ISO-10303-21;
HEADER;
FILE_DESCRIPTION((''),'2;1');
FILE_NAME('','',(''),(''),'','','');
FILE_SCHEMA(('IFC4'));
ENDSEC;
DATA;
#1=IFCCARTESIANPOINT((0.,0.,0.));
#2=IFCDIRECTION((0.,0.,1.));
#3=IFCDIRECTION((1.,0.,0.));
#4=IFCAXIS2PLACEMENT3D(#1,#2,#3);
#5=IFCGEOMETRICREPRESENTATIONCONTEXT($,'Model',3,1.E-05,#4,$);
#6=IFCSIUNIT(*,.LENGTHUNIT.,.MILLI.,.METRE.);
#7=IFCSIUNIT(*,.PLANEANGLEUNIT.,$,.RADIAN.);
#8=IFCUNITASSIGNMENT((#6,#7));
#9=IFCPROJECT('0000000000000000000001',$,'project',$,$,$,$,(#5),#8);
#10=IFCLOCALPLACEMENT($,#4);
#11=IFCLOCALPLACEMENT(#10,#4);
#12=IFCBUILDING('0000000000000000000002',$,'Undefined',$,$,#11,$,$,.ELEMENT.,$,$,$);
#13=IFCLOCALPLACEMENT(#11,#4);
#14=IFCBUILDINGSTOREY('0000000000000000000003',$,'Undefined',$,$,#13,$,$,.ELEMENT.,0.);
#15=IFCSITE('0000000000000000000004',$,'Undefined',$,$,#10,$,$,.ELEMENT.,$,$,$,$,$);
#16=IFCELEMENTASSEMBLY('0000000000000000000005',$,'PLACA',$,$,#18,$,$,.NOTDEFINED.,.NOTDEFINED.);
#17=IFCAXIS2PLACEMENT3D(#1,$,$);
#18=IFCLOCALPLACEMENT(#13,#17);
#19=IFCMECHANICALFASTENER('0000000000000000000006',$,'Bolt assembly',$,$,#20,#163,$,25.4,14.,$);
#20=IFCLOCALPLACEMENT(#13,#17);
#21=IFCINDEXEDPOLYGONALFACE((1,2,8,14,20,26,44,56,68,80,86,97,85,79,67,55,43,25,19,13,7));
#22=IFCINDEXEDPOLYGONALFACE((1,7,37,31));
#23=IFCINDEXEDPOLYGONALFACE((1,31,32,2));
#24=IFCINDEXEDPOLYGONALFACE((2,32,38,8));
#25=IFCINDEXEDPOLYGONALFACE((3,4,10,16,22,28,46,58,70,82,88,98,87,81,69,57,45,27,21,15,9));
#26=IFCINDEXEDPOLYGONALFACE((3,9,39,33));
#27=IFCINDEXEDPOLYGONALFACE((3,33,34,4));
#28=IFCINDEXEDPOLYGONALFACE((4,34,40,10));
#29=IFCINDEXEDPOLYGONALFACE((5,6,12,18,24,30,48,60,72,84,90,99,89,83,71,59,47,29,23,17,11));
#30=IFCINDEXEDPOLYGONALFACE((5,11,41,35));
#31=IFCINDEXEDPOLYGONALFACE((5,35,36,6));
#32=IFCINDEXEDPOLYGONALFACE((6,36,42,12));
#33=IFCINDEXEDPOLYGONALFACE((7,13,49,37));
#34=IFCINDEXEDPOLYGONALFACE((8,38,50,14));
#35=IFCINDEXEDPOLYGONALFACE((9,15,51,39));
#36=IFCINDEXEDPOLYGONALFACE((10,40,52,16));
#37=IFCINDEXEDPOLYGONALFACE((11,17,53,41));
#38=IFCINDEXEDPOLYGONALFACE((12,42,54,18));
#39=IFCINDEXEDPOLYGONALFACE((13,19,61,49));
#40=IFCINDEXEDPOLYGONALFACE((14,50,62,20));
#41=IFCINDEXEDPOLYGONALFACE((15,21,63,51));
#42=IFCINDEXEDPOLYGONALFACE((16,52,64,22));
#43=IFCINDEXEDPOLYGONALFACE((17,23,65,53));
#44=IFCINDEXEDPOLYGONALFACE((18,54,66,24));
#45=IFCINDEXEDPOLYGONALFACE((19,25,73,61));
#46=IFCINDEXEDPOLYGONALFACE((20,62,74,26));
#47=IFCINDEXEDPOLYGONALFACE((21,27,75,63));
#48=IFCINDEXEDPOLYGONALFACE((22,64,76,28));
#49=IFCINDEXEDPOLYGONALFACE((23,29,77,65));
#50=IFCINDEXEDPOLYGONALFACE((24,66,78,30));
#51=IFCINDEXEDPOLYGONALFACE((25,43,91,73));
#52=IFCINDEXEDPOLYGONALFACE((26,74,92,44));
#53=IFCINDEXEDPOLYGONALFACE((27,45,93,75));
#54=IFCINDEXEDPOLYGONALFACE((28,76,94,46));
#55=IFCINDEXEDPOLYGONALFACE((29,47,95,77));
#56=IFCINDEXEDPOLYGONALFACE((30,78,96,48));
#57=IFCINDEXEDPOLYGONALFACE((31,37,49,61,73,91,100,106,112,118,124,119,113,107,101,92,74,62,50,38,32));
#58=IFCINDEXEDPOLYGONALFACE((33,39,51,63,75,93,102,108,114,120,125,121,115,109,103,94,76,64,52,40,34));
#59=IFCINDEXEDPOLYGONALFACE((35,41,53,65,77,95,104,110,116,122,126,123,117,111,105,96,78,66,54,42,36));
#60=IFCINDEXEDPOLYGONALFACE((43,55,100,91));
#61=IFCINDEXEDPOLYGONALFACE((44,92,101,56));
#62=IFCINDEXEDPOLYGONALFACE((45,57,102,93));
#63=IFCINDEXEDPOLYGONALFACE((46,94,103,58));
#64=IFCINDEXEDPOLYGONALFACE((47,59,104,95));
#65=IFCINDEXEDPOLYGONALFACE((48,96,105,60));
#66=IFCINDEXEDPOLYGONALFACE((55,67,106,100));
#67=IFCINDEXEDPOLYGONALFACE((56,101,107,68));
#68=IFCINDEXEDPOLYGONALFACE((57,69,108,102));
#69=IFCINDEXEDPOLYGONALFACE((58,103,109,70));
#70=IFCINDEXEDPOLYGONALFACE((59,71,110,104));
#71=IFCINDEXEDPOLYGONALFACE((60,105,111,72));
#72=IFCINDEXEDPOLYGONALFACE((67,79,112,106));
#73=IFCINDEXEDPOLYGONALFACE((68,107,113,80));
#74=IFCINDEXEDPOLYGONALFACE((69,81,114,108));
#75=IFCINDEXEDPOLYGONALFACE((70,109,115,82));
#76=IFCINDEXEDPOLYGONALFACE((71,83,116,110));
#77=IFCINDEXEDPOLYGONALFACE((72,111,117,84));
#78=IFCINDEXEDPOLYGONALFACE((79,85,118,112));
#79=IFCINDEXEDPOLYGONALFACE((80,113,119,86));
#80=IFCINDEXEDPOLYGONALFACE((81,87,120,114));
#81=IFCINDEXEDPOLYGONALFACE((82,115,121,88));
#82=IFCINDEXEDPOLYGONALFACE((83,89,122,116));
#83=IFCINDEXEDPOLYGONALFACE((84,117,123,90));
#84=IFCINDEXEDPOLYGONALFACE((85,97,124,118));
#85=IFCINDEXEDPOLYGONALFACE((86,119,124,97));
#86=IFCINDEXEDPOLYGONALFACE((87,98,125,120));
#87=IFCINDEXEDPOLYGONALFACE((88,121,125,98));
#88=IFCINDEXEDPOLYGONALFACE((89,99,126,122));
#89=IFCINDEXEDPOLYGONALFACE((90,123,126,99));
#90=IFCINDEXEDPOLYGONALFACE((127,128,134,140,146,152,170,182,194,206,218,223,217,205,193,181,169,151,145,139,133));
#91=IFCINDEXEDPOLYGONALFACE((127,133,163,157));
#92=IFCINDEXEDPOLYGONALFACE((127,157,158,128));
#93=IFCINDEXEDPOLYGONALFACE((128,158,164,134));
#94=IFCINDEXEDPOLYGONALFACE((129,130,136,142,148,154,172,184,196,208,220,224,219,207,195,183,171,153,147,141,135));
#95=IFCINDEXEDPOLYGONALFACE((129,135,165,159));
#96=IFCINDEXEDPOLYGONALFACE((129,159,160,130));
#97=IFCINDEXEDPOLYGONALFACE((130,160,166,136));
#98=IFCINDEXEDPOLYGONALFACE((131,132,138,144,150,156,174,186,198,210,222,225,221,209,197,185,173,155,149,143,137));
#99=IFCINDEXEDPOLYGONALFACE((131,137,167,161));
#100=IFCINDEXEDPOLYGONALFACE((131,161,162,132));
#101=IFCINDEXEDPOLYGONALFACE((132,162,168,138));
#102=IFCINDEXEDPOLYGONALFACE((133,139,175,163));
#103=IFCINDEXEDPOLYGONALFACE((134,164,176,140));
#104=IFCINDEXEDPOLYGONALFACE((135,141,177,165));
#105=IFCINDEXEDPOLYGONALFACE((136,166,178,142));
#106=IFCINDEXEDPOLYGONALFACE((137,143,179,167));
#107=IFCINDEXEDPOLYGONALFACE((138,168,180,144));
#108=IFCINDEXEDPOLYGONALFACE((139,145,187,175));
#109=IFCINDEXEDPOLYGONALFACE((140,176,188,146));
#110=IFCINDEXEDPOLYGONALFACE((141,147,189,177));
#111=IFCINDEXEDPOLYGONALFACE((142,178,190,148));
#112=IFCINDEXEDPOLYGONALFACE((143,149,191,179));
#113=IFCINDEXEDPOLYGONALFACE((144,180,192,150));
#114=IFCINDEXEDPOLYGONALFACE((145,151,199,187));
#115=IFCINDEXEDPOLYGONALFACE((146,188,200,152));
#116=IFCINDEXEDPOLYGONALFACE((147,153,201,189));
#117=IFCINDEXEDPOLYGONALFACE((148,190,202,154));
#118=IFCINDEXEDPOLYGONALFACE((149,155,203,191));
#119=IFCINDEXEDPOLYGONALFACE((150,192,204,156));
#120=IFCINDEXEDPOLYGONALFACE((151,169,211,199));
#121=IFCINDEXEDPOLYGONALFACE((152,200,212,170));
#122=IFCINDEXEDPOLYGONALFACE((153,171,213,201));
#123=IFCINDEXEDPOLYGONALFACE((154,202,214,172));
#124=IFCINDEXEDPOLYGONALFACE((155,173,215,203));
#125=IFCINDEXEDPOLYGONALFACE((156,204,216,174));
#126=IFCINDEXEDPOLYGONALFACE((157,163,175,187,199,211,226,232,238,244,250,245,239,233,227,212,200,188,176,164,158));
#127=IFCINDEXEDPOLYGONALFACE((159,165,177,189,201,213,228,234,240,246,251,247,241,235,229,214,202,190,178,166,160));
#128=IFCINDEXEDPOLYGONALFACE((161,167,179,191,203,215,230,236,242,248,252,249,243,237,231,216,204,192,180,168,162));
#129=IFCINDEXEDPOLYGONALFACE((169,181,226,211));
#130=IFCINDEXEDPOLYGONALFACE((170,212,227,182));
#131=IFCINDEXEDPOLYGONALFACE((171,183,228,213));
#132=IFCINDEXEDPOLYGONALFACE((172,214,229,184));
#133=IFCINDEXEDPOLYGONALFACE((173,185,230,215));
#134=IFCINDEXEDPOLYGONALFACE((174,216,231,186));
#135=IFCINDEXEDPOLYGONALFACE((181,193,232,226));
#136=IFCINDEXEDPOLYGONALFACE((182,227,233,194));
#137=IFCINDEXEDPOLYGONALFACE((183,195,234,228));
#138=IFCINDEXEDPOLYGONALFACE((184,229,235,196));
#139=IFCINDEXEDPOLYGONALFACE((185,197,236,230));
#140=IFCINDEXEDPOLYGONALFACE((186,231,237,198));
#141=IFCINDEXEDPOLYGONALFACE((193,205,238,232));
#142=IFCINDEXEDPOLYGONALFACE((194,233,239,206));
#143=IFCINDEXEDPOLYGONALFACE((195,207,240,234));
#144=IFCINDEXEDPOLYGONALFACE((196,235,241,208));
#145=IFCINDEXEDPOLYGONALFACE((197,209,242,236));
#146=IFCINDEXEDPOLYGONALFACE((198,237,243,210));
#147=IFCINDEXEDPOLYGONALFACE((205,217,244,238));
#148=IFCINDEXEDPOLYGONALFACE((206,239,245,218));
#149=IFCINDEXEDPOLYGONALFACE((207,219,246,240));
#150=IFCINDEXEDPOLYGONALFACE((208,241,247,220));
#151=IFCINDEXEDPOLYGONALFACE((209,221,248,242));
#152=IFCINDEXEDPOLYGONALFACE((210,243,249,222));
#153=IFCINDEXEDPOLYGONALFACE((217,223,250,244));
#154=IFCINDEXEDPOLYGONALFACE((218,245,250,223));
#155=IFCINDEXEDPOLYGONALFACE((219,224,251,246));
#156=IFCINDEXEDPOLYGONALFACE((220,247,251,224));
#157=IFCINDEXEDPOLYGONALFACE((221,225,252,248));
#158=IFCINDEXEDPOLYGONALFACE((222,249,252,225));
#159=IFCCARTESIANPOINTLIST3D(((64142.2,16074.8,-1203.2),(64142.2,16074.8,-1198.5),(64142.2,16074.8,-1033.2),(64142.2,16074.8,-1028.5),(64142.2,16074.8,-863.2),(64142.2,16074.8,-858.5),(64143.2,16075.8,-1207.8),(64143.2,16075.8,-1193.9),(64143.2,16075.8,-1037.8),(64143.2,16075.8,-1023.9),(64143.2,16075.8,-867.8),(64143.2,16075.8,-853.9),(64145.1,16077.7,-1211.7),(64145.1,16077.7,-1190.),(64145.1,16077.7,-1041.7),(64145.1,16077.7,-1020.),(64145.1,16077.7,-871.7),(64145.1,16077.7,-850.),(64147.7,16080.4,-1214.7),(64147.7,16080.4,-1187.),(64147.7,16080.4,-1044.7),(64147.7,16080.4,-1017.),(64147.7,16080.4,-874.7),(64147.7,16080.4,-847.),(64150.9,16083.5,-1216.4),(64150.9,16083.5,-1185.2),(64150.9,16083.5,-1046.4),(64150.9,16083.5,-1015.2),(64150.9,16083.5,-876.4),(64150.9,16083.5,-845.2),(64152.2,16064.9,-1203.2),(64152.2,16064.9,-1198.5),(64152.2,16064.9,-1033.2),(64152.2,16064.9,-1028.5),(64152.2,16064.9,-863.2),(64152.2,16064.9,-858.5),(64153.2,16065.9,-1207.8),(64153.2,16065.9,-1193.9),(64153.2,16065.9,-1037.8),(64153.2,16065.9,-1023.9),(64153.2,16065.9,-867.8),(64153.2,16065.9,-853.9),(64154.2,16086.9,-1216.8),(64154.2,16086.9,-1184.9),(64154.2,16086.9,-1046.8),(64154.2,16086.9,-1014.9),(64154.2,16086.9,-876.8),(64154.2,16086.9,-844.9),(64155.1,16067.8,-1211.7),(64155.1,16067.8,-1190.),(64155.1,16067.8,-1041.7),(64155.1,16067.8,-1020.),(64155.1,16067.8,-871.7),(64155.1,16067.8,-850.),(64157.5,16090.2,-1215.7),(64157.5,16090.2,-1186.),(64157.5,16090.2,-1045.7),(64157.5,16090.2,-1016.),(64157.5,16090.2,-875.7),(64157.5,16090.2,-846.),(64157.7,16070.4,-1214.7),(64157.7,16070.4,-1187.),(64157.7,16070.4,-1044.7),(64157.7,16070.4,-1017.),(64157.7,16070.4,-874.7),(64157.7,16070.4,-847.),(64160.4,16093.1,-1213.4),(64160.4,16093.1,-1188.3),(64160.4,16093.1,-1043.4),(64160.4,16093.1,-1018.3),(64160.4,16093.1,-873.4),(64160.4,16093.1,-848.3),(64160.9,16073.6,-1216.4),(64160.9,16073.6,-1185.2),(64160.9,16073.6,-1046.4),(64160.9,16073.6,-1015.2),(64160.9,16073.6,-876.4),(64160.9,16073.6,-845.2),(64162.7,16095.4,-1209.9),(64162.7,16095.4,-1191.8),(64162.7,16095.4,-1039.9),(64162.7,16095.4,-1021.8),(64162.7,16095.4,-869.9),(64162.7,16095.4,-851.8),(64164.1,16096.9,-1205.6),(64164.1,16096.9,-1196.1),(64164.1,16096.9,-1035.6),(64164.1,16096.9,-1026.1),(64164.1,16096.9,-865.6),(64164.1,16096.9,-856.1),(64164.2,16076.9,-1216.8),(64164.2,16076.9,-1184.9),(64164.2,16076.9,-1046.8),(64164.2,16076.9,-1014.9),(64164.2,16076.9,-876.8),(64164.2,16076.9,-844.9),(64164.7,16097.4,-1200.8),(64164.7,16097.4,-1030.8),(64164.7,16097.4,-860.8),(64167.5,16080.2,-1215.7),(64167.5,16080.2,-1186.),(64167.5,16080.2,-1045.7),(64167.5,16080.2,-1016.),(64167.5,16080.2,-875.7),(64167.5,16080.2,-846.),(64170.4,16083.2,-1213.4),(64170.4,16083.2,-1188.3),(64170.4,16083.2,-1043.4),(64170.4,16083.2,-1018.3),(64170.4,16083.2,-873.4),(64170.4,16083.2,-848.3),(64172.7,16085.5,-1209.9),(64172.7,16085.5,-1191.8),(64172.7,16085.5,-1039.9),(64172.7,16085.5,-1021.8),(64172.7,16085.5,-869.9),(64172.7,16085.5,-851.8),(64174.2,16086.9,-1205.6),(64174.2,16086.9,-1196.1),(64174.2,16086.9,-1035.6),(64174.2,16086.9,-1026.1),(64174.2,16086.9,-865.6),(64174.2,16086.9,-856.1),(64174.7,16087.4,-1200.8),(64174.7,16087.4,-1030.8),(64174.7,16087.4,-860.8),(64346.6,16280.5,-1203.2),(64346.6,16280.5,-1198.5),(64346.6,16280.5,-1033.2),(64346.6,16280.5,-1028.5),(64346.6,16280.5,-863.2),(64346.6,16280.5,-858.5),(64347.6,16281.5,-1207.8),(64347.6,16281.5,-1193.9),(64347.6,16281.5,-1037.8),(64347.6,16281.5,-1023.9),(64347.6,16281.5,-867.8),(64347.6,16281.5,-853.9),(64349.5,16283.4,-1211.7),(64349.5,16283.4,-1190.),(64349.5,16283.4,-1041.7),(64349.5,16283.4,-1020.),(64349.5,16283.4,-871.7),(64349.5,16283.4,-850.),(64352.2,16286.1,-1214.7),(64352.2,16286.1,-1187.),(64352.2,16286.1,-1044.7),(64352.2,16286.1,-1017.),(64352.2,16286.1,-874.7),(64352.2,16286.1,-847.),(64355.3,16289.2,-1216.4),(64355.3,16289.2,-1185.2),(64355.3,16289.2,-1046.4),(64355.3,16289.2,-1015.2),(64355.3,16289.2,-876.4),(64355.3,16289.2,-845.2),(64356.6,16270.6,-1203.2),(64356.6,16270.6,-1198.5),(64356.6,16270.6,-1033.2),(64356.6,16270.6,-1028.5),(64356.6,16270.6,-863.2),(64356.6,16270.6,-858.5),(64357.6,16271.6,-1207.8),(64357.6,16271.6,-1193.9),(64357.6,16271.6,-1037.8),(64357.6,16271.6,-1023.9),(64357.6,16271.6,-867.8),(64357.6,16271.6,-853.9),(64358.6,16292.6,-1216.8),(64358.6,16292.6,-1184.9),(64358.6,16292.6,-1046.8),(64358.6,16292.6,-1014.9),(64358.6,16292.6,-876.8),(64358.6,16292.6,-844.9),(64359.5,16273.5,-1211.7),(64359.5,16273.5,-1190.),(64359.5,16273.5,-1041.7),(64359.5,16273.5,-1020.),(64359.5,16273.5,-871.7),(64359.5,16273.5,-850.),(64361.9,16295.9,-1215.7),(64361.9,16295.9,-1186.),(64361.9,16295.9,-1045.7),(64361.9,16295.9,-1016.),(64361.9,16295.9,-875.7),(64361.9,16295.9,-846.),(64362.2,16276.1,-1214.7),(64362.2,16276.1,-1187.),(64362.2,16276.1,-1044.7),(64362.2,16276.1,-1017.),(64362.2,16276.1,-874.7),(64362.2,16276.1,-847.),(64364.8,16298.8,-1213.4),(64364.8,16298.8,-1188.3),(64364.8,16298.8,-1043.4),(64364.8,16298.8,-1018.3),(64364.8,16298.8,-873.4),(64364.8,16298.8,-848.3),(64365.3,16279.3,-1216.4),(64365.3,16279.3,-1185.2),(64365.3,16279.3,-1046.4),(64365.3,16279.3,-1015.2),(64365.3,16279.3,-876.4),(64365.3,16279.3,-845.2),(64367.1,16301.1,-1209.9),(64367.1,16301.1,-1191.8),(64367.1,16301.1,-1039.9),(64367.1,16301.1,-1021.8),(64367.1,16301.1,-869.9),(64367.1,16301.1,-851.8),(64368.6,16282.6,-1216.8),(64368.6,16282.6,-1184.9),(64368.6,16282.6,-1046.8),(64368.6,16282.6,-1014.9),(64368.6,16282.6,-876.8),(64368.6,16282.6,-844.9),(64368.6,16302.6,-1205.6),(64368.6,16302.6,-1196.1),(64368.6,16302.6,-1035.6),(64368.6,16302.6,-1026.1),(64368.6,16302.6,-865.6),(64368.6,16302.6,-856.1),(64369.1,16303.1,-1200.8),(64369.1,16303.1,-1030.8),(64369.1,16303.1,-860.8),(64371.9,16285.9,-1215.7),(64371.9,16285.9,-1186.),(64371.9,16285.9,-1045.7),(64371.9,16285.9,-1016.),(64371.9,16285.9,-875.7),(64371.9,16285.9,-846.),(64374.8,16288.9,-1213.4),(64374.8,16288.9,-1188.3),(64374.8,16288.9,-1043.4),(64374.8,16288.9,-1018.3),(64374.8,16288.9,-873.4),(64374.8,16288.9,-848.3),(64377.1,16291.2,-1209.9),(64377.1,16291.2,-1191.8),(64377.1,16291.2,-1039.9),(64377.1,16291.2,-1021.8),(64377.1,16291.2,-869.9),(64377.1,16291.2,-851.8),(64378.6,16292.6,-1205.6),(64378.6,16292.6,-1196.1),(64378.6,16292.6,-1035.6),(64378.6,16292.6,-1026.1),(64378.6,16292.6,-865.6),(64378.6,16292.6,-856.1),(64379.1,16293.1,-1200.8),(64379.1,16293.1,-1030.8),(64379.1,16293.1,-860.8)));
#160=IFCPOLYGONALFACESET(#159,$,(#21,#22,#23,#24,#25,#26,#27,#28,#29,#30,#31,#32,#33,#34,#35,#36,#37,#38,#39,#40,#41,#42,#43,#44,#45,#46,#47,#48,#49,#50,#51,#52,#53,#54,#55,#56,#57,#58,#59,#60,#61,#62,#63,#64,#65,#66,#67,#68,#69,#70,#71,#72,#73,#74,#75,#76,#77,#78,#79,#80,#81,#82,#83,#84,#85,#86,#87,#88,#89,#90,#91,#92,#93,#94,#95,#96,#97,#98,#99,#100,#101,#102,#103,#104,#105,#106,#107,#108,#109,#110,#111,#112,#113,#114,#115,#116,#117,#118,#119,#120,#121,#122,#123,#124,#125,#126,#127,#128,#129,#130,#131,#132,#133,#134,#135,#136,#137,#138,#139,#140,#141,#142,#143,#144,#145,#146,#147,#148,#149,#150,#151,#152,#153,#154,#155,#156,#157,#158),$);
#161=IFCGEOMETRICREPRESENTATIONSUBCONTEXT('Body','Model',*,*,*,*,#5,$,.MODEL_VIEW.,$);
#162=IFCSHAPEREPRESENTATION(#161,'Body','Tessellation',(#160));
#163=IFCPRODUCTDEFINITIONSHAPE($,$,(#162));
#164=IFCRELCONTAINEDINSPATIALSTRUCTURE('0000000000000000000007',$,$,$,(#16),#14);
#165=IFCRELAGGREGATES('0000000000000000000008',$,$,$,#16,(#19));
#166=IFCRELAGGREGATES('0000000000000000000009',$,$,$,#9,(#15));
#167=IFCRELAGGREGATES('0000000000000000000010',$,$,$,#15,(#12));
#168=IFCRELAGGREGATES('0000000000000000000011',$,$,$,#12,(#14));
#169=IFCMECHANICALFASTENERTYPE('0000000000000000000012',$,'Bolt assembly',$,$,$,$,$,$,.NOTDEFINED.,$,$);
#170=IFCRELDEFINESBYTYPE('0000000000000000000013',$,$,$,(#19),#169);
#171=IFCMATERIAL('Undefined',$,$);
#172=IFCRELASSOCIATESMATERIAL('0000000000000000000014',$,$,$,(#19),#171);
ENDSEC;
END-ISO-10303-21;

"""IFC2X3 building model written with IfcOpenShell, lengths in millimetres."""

from ifc_helpers import new_model, si_unit, frame, origin_with_axes, origin_2d_with_axis, place, context, subcontext, project, spatial, circle, extrude, source, transform, mapped, material, type_object, element, aggregate, save


model = new_model("IFC2X3")

# Units and contexts
model_context = context("Model", 3, precision=1e-05, world=origin_with_axes())
body_context = subcontext(model_context, "Body", "Model", "MODEL_VIEW")
ifc_project = project(units=[si_unit("LENGTHUNIT", "METRE", prefix="MILLI"), si_unit("PLANEANGLEUNIT", "RADIAN")], contexts=[model_context])

# Site, building, storey
site_placement = place(None, origin_with_axes())
site = spatial("IfcSite", under=ifc_project, at=site_placement, Name="Undefined", CompositionType="ELEMENT")
building_placement = place(site_placement, origin_with_axes())
building = spatial("IfcBuilding", under=site, at=building_placement, Name="Undefined", CompositionType="ELEMENT")
storey_placement = place(building_placement, origin_with_axes())
storey = spatial("IfcBuildingStorey", under=building, at=storey_placement, Name="Undefined", CompositionType="ELEMENT", Elevation=0.0)

# Element assembly
assembly_1_placement = place(storey_placement, origin_with_axes())
assembly_1 = element("IfcElementAssembly", 1, at=assembly_1_placement, inside=storey, Name="PLACA", AssemblyPlace="NOTDEFINED", PredefinedType="NOTDEFINED")

# Mechanical fastener
ifc_material_1 = material(Name="Undefined")
mechanical_fastener_type = type_object("IfcMechanicalFastenerType", Name="Bolt assembly")
shared_shape_1 = source(origin_with_axes(), body_context, "Body", "SweptSolid", [
    extrude(circle(Radius=16.0, at=origin_2d_with_axis()), frame((0.0, 0.0, 0.0), z_axis=(0.0, 1.0, 0.0), x_axis=(1.0, 0.0, 0.0)), (0.0, 0.0, 1.0), 14.1),
])
mechanical_fastener_1_placement = place(assembly_1_placement, frame((64163.4, 16076.1, -1030.8), z_axis=(0.000001, 0.000001, 1.0), x_axis=(0.704896, 0.709311, -0.000002)))
mechanical_fastener_1 = element("IfcMechanicalFastener", 2, at=mechanical_fastener_1_placement, type_object=mechanical_fastener_type, material=ifc_material_1, Name="Bolt assembly", NominalDiameter=25.4, NominalLength=14.0, context=body_context, shape_type="MappedRepresentation", body=[
    mapped(shared_shape_1, transform((0.0, 0.0, -170.0))),
    mapped(shared_shape_1, transform((290.0, 0.0, -170.0))),
    mapped(shared_shape_1, transform((0.0, 0.0, 0.0))),
    mapped(shared_shape_1, transform((290.0, 0.0, 0.0))),
    mapped(shared_shape_1, transform((0.0, 0.0, 170.0))),
    mapped(shared_shape_1, transform((290.0, 0.0, 170.0))),
])
aggregate(assembly_1, [mechanical_fastener_1])

save(model, "model.ifc")
